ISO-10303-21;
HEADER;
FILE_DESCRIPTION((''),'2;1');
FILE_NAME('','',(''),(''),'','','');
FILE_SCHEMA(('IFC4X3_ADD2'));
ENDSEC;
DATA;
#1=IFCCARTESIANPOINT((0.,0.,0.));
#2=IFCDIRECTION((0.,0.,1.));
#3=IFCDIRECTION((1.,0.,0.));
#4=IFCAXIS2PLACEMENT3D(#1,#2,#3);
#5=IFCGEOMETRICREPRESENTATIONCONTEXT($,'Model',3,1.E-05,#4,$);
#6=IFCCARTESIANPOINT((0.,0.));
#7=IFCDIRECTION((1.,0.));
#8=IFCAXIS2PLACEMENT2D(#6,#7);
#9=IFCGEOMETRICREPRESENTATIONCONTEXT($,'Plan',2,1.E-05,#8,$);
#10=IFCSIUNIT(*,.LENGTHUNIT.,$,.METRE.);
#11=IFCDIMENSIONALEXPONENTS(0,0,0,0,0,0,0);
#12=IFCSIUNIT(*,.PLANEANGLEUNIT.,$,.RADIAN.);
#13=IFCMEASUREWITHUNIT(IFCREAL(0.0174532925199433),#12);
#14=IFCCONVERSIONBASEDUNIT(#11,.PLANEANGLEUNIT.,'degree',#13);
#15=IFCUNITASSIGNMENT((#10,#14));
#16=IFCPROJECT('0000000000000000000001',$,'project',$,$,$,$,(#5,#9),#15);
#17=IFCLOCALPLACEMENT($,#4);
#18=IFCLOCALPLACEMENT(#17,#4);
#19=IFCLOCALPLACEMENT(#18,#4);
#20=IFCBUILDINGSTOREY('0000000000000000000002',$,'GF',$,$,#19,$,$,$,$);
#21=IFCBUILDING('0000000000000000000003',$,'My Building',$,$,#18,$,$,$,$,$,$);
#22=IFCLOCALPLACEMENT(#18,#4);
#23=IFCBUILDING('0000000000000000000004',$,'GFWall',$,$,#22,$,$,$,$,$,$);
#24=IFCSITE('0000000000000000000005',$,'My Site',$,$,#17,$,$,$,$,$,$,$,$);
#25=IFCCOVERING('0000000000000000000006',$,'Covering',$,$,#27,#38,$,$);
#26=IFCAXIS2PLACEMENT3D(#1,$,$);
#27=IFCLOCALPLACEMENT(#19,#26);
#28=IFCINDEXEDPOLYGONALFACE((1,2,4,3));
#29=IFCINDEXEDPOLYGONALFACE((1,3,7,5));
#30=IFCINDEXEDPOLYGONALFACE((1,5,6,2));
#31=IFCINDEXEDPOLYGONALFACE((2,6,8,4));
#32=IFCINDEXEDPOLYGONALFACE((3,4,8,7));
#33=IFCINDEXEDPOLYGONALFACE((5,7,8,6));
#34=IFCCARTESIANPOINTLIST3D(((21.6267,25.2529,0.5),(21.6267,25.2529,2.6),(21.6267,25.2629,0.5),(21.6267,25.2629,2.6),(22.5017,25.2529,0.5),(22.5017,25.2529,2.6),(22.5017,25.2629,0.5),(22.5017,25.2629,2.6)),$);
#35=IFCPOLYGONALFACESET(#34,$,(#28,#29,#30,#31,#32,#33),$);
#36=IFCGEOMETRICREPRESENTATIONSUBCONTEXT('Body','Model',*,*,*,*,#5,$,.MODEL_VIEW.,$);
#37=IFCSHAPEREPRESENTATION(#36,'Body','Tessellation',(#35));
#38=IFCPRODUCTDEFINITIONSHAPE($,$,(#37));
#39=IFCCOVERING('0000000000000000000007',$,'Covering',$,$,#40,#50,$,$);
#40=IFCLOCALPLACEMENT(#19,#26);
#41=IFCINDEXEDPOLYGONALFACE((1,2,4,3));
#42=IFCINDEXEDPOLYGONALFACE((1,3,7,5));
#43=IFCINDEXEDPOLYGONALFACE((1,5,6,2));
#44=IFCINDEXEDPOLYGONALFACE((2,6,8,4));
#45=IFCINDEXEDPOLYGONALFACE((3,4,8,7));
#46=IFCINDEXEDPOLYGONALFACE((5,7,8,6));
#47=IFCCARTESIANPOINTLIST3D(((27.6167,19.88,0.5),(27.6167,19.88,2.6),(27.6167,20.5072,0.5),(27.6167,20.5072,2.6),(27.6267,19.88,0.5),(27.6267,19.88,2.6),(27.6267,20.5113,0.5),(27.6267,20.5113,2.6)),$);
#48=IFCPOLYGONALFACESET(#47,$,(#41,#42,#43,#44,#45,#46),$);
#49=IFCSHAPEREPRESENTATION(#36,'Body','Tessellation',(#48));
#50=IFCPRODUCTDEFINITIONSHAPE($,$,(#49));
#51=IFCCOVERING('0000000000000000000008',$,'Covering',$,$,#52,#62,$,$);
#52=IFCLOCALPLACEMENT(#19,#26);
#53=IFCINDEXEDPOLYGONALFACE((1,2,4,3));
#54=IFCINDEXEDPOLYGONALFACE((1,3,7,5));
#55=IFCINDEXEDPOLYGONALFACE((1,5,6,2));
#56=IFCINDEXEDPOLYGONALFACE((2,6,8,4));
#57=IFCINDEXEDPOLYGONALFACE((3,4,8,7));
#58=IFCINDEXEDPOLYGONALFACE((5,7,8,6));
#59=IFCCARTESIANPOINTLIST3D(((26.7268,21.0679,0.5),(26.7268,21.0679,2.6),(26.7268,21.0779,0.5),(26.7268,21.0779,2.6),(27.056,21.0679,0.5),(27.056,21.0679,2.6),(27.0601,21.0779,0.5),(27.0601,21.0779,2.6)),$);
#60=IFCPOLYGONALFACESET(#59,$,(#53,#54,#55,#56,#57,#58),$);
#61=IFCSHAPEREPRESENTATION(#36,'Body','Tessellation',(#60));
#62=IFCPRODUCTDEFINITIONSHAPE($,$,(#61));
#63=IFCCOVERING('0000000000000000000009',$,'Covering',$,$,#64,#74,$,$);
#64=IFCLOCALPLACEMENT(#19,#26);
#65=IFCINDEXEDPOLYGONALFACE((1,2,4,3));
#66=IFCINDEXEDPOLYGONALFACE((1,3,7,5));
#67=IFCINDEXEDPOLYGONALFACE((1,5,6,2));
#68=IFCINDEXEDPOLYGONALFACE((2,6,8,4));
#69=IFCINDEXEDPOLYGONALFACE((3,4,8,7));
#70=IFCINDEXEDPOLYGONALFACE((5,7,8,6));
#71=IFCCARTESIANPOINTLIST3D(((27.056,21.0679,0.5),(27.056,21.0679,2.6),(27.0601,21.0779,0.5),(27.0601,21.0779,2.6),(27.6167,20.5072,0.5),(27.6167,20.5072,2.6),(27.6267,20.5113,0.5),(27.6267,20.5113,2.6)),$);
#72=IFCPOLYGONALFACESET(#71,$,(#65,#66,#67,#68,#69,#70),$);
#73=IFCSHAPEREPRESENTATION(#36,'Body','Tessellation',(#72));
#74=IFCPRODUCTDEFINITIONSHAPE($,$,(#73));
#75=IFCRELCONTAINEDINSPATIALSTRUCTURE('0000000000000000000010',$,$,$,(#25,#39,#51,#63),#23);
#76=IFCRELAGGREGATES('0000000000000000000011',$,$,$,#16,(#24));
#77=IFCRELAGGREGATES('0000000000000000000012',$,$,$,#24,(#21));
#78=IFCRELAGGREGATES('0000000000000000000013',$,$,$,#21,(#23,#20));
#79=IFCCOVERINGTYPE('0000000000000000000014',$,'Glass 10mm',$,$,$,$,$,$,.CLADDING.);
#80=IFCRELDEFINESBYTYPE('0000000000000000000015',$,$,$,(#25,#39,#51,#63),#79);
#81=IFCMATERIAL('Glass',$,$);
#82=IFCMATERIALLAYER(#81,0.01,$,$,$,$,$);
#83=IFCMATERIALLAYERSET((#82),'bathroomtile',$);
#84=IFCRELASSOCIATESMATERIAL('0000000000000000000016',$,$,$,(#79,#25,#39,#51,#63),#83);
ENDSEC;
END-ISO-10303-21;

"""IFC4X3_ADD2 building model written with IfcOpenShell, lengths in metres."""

from ifc_helpers import new_model, entity, si_unit, converted_unit, frame, origin_with_axes, origin_2d_with_axis, place, context, subcontext, project, spatial, line, indexed_curve, outline, extrude, material, layer, layer_set, layer_usage, type_object, element, save


model = new_model("IFC4X3_ADD2")

# Units and contexts
model_context = context("Model", 3, precision=1e-05, world=origin_with_axes())
plan_context = context("Plan", 2, precision=1e-05, world=origin_2d_with_axis())
body_context_1 = subcontext(model_context, "Body", "Model", "MODEL_VIEW")
ifc_project = project(units=[si_unit("LENGTHUNIT", "METRE"), converted_unit("PLANEANGLEUNIT", "degree", entity("IfcReal", 0.0174532925199433), si_unit("PLANEANGLEUNIT", "RADIAN"), dimensions=[0, 0, 0, 0, 0, 0, 0])], contexts=[model_context, plan_context])

# Site, buildings
site_placement = place(None, origin_with_axes())
site = spatial("IfcSite", under=ifc_project, at=site_placement, Name="My Site")
building_1_placement = place(site_placement, origin_with_axes())
building_1 = spatial("IfcBuilding", under=site, at=building_1_placement, Name="My Building")
building_2_placement = place(building_1_placement, origin_with_axes())
building_2 = spatial("IfcBuilding", under=building_1, at=building_2_placement, Name="GFWall")

# Shared definitions
storey_placement = place(building_1_placement, origin_with_axes())
storey = spatial("IfcBuildingStorey", under=building_1, at=storey_placement, Name="GF")

# Coverings
ifc_material_1 = material(Name="Glass")
ifc_layer_1 = layer(ifc_material_1, 0.01)
ifc_layer_set_1 = layer_set([ifc_layer_1], Name="bathroomtile")
covering_type_1 = type_object("IfcCoveringType", Name="Glass 10mm", PredefinedType="CLADDING", material=ifc_layer_set_1)
ifc_layer_usage_1 = layer_usage(ifc_layer_set_1, "AXIS2", "NEGATIVE", 0.0)
covering_1_placement = place(building_2_placement, frame((21.6267, 25.2629, 0.5), z_axis=(0.0, 0.0, 1.0), x_axis=(1.0, 0.0, 0.0)))
element("IfcCovering", 1, at=covering_1_placement, inside=building_2, type_object=covering_type_1, material=ifc_layer_usage_1, Name="Covering", context=body_context_1, shape_type="SweptSolid", body=[
    extrude(outline(indexed_curve([(0.0, -0.01), (0.0, 0.0), (0.875, 0.0), (0.875, -0.01)], segments=[line(1, 2, 3, 4, 1)])), origin_with_axes(), (0.0, 0.0, 1.0), 2.1),
])
ifc_layer_usage_2 = layer_usage(ifc_layer_set_1, "AXIS2", "NEGATIVE", 0.0)
covering_2_placement = place(building_2_placement, frame((27.6167, 19.88, 0.5), z_axis=(0.0, 0.0, 1.0), x_axis=(0.0, 1.0, 0.0)))
element("IfcCovering", 2, at=covering_2_placement, inside=building_2, type_object=covering_type_1, material=ifc_layer_usage_2, Name="Covering", context=body_context_1, shape_type="SweptSolid", body=[
    extrude(outline(indexed_curve([(0.0, -0.01), (0.0, 0.0), (0.6272, 0.0), (0.6314, -0.01)], segments=[line(1, 2, 3, 4, 1)])), origin_with_axes(), (0.0, 0.0, 1.0), 2.1),
])
ifc_layer_usage_3 = layer_usage(ifc_layer_set_1, "AXIS2", "NEGATIVE", 0.0)
covering_3_placement = place(building_2_placement, frame((26.7268, 21.0779, 0.5), z_axis=(0.0, 0.0, 1.0), x_axis=(1.0, 0.0, 0.0)))
element("IfcCovering", 3, at=covering_3_placement, inside=building_2, type_object=covering_type_1, material=ifc_layer_usage_3, Name="Covering", context=body_context_1, shape_type="SweptSolid", body=[
    extrude(outline(indexed_curve([(0.0, -0.01), (0.0, 0.0), (0.3333, 0.0), (0.3292, -0.01)], segments=[line(1, 2, 3, 4, 1)])), origin_with_axes(), (0.0, 0.0, 1.0), 2.1),
])
ifc_layer_usage_4 = layer_usage(ifc_layer_set_1, "AXIS2", "NEGATIVE", 0.0)
covering_4_placement = place(building_2_placement, frame((27.0601, 21.0779, 0.5), z_axis=(0.0, 0.0, 1.0), x_axis=(0.707107, -0.707107, 0.0)))
element("IfcCovering", 4, at=covering_4_placement, inside=building_2, type_object=covering_type_1, material=ifc_layer_usage_4, Name="Covering", context=body_context_1, shape_type="SweptSolid", body=[
    extrude(outline(indexed_curve([(0.0041, -0.01), (0.0, 0.0), (0.8012, 0.0), (0.7971, -0.01)], segments=[line(1, 2, 3, 4, 1)])), origin_with_axes(), (0.0, 0.0, 1.0), 2.1),
])

save(model, "model.ifc")
